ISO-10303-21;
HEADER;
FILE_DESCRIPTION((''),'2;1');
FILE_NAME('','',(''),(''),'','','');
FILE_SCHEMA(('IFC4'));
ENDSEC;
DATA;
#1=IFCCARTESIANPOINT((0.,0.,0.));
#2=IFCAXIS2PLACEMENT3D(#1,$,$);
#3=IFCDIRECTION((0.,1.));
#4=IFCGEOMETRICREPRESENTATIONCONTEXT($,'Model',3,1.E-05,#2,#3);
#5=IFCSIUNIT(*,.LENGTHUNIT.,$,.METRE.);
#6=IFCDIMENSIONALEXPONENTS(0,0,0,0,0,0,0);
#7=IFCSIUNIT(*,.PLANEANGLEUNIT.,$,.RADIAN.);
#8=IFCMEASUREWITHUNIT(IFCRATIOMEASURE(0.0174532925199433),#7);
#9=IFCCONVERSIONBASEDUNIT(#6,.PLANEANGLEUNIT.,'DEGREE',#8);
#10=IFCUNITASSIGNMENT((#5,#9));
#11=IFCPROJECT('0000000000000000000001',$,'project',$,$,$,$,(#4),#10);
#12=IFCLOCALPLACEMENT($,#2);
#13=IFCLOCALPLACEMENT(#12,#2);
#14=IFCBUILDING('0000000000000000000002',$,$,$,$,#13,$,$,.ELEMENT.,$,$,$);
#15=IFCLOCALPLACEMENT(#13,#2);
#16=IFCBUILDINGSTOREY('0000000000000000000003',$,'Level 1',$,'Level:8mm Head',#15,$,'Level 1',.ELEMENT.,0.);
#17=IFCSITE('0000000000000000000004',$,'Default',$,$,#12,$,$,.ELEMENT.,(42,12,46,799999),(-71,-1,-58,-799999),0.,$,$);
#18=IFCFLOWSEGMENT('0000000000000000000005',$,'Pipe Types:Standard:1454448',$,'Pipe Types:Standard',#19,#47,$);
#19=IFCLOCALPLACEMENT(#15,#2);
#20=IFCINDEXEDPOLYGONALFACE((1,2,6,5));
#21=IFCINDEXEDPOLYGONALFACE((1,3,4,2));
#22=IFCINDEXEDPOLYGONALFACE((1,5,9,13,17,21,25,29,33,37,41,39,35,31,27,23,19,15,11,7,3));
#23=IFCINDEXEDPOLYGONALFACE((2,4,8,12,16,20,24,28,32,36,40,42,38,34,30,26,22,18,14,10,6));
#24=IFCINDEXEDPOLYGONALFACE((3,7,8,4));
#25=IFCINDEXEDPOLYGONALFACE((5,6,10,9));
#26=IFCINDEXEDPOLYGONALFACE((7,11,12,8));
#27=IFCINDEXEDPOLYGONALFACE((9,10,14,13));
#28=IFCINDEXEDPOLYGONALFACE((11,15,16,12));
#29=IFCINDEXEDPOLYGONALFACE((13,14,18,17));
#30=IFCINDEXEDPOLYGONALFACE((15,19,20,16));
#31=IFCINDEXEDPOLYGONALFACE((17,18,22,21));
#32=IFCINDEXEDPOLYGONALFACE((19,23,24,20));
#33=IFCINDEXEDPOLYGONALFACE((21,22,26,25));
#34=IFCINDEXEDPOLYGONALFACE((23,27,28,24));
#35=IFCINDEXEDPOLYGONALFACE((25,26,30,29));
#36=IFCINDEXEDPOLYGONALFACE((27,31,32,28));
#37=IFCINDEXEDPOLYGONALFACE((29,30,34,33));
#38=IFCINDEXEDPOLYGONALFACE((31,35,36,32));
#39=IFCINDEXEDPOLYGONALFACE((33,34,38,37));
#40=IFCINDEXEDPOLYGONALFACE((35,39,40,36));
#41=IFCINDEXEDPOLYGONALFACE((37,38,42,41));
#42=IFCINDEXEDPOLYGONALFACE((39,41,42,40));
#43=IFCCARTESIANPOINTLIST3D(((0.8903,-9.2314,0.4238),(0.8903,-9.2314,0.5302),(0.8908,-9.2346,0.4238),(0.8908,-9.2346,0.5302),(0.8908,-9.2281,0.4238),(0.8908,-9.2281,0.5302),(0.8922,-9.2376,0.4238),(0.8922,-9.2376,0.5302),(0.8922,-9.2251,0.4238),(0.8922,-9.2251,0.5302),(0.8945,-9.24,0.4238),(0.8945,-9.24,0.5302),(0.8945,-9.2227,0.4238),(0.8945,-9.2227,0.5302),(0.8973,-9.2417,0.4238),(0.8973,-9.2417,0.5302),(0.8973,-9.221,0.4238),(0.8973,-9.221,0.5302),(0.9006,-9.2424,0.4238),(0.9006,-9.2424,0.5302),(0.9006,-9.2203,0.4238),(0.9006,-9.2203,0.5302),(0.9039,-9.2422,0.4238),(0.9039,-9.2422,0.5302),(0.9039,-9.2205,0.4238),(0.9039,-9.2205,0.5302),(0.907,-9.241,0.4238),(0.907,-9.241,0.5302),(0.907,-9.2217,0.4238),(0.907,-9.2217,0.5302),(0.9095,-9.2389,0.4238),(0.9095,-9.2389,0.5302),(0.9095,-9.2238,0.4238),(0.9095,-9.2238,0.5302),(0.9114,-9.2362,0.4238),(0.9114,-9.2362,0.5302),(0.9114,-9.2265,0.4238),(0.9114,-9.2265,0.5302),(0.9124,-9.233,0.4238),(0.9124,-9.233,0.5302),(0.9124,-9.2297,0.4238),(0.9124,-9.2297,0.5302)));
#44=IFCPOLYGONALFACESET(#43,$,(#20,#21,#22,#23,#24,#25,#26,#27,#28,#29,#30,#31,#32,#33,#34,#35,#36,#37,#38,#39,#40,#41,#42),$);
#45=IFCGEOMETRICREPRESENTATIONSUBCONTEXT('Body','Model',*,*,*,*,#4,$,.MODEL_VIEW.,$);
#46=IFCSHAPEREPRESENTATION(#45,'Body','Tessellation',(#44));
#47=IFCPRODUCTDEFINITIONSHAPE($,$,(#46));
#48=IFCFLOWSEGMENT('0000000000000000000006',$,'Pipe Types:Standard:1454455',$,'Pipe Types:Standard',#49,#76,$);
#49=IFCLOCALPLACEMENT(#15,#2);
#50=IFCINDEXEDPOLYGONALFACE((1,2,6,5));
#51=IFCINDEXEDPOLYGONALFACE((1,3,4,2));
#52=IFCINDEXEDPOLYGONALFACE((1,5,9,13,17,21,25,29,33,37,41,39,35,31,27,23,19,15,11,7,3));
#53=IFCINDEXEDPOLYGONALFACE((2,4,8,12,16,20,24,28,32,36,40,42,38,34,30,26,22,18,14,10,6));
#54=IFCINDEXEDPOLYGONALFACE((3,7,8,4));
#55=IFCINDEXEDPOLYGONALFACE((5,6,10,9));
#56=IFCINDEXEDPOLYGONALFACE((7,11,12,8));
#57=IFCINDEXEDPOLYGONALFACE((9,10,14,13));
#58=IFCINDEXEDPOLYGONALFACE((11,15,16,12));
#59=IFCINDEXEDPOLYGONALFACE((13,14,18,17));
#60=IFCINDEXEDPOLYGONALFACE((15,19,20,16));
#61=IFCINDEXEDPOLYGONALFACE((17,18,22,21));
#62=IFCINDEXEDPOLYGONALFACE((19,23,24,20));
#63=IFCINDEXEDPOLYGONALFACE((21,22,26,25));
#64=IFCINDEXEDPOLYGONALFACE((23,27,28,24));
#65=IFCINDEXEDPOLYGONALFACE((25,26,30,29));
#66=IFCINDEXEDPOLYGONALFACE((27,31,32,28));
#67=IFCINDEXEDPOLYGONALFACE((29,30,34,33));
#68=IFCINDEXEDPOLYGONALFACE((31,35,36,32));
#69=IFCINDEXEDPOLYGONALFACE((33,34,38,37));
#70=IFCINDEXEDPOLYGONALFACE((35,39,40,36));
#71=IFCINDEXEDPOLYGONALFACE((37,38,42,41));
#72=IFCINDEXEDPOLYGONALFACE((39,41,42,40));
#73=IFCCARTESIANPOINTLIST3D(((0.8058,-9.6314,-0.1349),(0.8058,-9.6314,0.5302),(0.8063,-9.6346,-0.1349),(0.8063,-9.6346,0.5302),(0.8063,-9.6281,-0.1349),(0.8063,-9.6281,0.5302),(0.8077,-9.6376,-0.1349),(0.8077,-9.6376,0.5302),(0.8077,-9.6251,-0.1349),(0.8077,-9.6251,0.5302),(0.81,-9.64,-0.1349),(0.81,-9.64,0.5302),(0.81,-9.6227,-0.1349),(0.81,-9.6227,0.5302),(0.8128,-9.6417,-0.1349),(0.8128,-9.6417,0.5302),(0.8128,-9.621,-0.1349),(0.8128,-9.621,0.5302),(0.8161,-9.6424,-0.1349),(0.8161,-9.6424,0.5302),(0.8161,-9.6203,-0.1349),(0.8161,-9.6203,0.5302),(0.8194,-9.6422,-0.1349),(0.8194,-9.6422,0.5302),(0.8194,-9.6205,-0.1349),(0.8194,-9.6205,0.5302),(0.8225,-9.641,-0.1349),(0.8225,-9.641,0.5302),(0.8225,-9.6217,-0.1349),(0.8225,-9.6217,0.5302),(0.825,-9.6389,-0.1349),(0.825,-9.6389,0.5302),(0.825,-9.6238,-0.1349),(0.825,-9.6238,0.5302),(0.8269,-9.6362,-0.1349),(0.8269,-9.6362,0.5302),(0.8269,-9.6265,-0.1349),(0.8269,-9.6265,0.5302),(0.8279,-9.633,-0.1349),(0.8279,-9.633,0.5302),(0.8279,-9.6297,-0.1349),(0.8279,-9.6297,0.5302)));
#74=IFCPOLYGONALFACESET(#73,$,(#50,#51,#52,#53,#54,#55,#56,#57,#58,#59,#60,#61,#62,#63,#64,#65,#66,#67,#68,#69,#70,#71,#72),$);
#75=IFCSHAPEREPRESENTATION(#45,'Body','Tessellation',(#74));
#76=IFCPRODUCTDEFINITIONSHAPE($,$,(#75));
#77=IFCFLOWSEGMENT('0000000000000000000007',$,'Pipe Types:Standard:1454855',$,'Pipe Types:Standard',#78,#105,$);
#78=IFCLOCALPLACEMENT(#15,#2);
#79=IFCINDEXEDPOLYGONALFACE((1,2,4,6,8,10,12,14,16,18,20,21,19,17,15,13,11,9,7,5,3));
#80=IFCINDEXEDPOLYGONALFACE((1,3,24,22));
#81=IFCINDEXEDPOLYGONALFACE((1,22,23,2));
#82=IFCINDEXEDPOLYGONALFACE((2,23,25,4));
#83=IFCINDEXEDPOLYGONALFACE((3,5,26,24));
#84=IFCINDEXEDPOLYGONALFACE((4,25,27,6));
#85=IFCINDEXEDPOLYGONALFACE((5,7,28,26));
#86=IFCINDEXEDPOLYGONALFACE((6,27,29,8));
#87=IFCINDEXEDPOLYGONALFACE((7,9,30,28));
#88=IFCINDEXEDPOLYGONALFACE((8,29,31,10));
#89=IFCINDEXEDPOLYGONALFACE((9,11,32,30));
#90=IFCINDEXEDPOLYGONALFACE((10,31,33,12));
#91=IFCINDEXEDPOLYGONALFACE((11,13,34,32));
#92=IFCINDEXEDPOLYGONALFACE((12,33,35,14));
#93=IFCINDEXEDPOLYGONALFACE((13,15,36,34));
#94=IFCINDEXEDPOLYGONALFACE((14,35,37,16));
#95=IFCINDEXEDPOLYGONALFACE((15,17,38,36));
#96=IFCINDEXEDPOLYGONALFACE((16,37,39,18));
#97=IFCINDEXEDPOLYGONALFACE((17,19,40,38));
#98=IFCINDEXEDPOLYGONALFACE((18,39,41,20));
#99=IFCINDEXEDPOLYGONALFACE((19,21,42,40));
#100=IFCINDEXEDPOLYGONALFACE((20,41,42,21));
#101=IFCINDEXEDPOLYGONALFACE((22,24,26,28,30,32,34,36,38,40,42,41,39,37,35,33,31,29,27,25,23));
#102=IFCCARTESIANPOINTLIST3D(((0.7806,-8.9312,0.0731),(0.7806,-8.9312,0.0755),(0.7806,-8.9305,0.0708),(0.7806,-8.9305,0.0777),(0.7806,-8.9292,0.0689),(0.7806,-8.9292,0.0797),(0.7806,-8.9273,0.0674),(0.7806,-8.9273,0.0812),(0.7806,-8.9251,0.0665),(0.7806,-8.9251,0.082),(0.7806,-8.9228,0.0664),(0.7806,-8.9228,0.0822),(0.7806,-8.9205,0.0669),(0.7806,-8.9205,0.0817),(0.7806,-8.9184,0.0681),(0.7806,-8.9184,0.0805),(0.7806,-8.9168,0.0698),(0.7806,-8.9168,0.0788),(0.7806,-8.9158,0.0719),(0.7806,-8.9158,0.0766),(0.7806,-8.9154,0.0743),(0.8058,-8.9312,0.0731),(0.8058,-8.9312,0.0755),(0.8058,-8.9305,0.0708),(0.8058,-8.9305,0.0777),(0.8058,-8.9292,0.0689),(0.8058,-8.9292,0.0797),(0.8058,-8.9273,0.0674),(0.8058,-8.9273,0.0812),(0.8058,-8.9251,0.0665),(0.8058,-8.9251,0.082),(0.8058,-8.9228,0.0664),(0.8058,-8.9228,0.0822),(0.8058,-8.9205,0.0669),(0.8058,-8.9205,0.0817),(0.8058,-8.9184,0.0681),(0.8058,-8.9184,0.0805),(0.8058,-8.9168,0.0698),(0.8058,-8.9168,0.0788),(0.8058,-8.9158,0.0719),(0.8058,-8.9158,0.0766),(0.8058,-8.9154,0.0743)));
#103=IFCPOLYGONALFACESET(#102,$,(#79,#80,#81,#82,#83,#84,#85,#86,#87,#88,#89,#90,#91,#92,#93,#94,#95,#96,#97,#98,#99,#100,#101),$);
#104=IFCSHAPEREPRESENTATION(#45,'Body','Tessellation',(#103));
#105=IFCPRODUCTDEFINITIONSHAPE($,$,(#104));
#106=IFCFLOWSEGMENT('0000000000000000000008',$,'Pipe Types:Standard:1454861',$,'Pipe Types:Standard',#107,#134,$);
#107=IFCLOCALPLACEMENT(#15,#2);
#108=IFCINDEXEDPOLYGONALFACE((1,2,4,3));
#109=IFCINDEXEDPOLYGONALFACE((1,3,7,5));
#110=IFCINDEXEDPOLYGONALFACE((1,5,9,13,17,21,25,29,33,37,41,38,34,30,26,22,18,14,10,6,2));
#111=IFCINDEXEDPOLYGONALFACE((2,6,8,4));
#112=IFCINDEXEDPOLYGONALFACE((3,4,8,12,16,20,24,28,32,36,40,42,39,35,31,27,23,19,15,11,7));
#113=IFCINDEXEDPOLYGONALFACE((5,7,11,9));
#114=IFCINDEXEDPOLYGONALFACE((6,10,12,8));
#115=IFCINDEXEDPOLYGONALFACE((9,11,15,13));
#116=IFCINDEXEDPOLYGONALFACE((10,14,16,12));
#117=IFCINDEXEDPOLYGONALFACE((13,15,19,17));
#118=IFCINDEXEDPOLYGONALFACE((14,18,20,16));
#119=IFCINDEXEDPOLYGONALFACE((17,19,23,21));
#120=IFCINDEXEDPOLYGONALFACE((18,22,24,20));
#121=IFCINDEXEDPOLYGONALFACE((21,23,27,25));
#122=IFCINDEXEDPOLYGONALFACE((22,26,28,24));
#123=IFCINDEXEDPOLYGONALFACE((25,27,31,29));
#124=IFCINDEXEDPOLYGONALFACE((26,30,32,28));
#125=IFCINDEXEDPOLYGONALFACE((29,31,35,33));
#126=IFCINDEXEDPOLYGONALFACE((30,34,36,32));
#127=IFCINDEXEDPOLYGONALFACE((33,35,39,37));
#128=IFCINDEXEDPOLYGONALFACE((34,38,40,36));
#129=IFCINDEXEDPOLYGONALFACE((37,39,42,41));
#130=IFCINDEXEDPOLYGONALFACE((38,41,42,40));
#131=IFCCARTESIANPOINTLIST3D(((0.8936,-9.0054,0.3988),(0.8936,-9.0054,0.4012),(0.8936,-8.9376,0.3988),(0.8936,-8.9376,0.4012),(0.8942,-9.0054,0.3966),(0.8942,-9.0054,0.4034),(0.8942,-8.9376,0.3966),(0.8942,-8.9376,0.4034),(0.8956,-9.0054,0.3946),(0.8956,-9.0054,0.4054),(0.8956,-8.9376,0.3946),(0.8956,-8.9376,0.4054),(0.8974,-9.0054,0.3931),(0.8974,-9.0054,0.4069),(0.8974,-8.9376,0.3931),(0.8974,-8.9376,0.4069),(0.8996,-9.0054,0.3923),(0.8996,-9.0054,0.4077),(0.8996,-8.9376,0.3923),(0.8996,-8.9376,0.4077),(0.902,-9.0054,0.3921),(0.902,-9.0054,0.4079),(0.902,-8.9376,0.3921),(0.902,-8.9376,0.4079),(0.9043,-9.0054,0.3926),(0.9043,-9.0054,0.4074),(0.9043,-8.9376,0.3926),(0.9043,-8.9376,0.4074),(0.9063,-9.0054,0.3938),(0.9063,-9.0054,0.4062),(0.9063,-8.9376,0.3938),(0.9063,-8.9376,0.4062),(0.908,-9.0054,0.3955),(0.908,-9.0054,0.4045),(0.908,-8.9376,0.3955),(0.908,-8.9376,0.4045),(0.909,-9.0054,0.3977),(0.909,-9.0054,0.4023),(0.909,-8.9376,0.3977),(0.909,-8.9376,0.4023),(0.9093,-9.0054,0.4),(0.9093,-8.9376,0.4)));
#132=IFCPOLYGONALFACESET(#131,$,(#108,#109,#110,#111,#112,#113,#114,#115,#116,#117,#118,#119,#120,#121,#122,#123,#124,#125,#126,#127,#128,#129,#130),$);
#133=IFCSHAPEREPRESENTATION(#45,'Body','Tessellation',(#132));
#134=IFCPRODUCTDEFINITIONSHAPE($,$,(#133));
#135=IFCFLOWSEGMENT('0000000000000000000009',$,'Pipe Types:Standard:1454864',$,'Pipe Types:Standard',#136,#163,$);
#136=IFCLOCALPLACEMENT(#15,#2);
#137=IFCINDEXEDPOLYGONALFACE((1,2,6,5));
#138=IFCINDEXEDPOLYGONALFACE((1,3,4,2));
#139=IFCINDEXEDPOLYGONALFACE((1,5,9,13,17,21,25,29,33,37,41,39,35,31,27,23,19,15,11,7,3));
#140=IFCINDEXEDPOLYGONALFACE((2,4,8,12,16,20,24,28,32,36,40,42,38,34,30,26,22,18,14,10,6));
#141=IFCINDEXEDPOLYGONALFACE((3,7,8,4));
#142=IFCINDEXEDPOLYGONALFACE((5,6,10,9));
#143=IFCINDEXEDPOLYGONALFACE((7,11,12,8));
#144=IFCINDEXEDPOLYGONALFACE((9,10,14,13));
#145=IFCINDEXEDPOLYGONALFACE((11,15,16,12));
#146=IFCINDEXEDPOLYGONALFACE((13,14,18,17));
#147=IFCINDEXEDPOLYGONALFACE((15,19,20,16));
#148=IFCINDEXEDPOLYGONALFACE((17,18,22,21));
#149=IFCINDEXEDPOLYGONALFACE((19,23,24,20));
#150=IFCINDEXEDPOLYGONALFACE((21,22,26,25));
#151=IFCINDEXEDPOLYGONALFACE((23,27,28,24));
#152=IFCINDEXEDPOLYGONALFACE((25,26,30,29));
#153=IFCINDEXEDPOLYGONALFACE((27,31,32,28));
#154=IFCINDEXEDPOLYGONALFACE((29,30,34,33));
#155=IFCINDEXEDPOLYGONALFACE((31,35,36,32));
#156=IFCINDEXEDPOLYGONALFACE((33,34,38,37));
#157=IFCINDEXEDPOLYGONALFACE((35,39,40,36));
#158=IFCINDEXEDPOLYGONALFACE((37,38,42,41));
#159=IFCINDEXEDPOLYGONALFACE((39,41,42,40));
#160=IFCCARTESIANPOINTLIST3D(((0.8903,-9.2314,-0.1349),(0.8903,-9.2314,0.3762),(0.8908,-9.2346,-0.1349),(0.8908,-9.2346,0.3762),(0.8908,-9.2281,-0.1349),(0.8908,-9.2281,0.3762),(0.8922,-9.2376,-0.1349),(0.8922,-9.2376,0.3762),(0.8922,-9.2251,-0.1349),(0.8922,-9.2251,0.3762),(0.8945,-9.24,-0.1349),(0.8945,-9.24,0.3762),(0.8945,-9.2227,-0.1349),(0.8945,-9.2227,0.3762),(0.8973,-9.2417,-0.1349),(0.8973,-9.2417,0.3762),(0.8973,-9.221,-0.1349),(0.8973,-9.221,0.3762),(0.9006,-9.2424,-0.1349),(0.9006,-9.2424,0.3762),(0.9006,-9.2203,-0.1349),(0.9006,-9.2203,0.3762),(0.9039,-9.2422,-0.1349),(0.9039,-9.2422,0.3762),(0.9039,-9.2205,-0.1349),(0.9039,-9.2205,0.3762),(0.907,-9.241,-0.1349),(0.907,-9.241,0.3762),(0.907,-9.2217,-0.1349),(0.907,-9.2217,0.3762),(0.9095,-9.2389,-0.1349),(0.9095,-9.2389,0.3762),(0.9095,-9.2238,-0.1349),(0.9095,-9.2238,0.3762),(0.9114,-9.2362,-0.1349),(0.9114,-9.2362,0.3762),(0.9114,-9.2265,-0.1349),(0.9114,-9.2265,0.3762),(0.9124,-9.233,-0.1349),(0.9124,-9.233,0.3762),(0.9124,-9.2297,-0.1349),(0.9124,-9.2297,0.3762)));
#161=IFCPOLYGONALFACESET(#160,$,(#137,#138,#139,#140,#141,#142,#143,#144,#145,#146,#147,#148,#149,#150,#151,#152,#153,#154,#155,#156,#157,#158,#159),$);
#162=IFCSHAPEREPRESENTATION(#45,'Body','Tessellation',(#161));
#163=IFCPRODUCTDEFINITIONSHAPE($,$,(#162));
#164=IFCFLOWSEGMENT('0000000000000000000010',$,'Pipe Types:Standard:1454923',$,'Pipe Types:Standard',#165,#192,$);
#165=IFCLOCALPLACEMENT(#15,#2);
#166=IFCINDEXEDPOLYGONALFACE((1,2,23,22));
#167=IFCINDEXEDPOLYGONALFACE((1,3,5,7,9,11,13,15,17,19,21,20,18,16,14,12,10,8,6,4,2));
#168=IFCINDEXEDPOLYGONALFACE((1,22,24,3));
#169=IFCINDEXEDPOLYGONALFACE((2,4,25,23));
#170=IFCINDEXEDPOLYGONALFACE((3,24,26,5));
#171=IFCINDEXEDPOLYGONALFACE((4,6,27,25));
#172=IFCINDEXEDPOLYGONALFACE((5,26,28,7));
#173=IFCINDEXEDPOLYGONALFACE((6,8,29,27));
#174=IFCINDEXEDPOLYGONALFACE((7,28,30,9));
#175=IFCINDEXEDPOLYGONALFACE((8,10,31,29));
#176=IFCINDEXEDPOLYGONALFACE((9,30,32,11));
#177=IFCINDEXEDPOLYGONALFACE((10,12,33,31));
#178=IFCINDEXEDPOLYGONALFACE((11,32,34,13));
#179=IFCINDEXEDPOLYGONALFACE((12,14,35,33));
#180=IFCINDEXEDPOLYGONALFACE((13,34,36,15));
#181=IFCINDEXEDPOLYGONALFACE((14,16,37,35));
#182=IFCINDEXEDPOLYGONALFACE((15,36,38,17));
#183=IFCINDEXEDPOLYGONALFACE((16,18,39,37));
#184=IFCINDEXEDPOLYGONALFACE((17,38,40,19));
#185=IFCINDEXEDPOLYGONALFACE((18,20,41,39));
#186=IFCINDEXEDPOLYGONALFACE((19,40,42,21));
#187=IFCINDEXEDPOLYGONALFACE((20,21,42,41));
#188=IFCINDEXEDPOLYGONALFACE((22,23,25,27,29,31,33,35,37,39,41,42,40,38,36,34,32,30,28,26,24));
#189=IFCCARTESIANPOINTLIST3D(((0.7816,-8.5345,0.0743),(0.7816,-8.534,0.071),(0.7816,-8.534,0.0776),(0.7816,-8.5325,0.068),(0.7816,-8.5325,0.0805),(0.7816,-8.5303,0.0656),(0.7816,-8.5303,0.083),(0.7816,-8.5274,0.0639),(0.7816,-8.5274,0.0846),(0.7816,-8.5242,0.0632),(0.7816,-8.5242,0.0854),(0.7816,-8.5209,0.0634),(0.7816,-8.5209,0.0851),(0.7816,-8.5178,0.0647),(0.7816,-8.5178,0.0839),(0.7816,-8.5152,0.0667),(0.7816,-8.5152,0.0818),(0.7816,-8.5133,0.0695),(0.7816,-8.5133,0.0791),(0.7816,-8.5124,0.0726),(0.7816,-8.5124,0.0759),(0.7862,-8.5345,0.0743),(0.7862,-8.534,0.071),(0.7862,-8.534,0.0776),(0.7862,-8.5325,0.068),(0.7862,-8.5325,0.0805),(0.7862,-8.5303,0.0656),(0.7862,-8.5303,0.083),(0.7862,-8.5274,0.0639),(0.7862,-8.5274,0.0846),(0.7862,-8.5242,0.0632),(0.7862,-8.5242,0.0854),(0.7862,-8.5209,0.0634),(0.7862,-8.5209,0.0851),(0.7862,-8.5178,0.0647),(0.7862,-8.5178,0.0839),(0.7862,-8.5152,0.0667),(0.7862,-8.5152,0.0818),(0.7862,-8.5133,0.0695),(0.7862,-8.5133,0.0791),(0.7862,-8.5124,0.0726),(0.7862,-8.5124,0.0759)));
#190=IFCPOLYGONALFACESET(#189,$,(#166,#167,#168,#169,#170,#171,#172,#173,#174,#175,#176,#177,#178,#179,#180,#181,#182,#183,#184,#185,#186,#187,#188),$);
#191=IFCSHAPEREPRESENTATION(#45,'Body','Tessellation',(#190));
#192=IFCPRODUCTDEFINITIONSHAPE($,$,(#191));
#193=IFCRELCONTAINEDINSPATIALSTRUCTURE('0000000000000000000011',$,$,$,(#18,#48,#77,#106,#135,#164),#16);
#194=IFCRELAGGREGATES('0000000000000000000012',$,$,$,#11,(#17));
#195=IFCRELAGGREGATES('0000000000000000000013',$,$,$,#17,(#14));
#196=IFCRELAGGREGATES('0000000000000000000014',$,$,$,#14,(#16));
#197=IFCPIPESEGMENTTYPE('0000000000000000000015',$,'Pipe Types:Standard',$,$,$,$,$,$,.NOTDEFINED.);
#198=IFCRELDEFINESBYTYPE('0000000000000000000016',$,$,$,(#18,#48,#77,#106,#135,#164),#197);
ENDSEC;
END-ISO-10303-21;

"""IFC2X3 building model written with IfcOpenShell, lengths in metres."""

from ifc_helpers import new_model, entity, si_unit, converted_unit, direction, frame, frame_2d, origin, origin_2d_with_axis, place, context, subcontext, project, spatial, circle, extrude, type_object, element, save


model = new_model("IFC2X3")

# Units and contexts
model_context = context("Model", 3, precision=1e-05, world=origin(), true_north=direction((0.0, 1.0)))
body_context = subcontext(model_context, "Body", "Model", "MODEL_VIEW")
ifc_project = project(units=[si_unit("LENGTHUNIT", "METRE"), converted_unit("PLANEANGLEUNIT", "DEGREE", entity("IfcRatioMeasure", 0.0174532925199433), si_unit("PLANEANGLEUNIT", "RADIAN"), dimensions=[0, 0, 0, 0, 0, 0, 0])], contexts=[model_context])

# Site, building, storey
site_placement = place(None, origin())
site = spatial("IfcSite", under=ifc_project, at=site_placement, Name="Default", CompositionType="ELEMENT", RefLatitude=(42, 12, 46, 799999), RefLongitude=(-71, -1, -58, -799999), RefElevation=0.0)
building_placement = place(site_placement, origin())
building = spatial("IfcBuilding", under=site, at=building_placement, CompositionType="ELEMENT")
storey_placement = place(building_placement, origin())
storey = spatial("IfcBuildingStorey", under=building, at=storey_placement, Name="Level 1", ObjectType="Level:8mm Head", LongName="Level 1", CompositionType="ELEMENT", Elevation=0.0)

# Flow segments
pipe_segment_type = type_object("IfcPipeSegmentType", Name="Pipe Types:Standard", PredefinedType="NOTDEFINED")
flow_segment_1_placement = place(storey_placement, origin())
element("IfcFlowSegment", 1, at=flow_segment_1_placement, inside=storey, type_object=pipe_segment_type, Name="Pipe Types:Standard:1454448", ObjectType="Pipe Types:Standard", context=body_context, shape_type="SweptSolid", body=[
    extrude(circle(Radius=0.0111, at=frame_2d((0.0, 0.0), x_axis=(1.0, 0.0))), frame((0.9014, -9.2314, 0.4238), z_axis=(0.0, 0.0, 1.0), x_axis=(-1.0, 0.0, 0.0)), (0.0, 0.0, 1.0), 0.1063),
])
flow_segment_2_placement = place(storey_placement, origin())
element("IfcFlowSegment", 2, at=flow_segment_2_placement, inside=storey, type_object=pipe_segment_type, Name="Pipe Types:Standard:1454455", ObjectType="Pipe Types:Standard", context=body_context, shape_type="SweptSolid", body=[
    extrude(circle(Radius=0.0111, at=frame_2d((0.0, 0.0), x_axis=(1.0, 0.0))), frame((0.8169, -9.6314, -0.1349), z_axis=(0.0, 0.0, 1.0), x_axis=(-1.0, 0.0, 0.0)), (0.0, 0.0, 1.0), 0.6651),
])
flow_segment_3_placement = place(storey_placement, origin())
element("IfcFlowSegment", 3, at=flow_segment_3_placement, inside=storey, type_object=pipe_segment_type, Name="Pipe Types:Standard:1454855", ObjectType="Pipe Types:Standard", context=body_context, shape_type="SweptSolid", body=[
    extrude(circle(Radius=0.0079, at=frame_2d((0.0, 0.0), x_axis=(1.0, 0.0))), frame((0.7806, -8.9234, 0.0743), z_axis=(1.0, 0.0, 0.000195), x_axis=(0.0, 1.0, 0.0)), (0.0, 0.0, 1.0), 0.0252),
])
flow_segment_4_placement = place(storey_placement, origin())
element("IfcFlowSegment", 4, at=flow_segment_4_placement, inside=storey, type_object=pipe_segment_type, Name="Pipe Types:Standard:1454861", ObjectType="Pipe Types:Standard", context=body_context, shape_type="SweptSolid", body=[
    extrude(circle(Radius=0.0079, at=origin_2d_with_axis()), frame((0.9014, -9.0054, 0.4), z_axis=(0.0, 1.0, 0.0), x_axis=(1.0, 0.0, 0.0)), (0.0, 0.0, 1.0), 0.0678),
])
flow_segment_5_placement = place(storey_placement, origin())
element("IfcFlowSegment", 5, at=flow_segment_5_placement, inside=storey, type_object=pipe_segment_type, Name="Pipe Types:Standard:1454864", ObjectType="Pipe Types:Standard", context=body_context, shape_type="SweptSolid", body=[
    extrude(circle(Radius=0.0111, at=origin_2d_with_axis()), frame((0.9014, -9.2314, -0.1349), z_axis=(0.0, 0.0, 1.0), x_axis=(-1.0, 0.0, 0.0)), (0.0, 0.0, 1.0), 0.5111),
])
flow_segment_6_placement = place(storey_placement, origin())
element("IfcFlowSegment", 6, at=flow_segment_6_placement, inside=storey, type_object=pipe_segment_type, Name="Pipe Types:Standard:1454923", ObjectType="Pipe Types:Standard", context=body_context, shape_type="SweptSolid", body=[
    extrude(circle(Radius=0.0111, at=frame_2d((0.0, 0.0), x_axis=(1.0, 0.0))), frame((0.7816, -8.5234, 0.0743), z_axis=(1.0, 0.0, 0.0), x_axis=(0.0, -1.0, 0.0)), (0.0, 0.0, 1.0), 0.0046),
])

save(model, "model.ifc")
